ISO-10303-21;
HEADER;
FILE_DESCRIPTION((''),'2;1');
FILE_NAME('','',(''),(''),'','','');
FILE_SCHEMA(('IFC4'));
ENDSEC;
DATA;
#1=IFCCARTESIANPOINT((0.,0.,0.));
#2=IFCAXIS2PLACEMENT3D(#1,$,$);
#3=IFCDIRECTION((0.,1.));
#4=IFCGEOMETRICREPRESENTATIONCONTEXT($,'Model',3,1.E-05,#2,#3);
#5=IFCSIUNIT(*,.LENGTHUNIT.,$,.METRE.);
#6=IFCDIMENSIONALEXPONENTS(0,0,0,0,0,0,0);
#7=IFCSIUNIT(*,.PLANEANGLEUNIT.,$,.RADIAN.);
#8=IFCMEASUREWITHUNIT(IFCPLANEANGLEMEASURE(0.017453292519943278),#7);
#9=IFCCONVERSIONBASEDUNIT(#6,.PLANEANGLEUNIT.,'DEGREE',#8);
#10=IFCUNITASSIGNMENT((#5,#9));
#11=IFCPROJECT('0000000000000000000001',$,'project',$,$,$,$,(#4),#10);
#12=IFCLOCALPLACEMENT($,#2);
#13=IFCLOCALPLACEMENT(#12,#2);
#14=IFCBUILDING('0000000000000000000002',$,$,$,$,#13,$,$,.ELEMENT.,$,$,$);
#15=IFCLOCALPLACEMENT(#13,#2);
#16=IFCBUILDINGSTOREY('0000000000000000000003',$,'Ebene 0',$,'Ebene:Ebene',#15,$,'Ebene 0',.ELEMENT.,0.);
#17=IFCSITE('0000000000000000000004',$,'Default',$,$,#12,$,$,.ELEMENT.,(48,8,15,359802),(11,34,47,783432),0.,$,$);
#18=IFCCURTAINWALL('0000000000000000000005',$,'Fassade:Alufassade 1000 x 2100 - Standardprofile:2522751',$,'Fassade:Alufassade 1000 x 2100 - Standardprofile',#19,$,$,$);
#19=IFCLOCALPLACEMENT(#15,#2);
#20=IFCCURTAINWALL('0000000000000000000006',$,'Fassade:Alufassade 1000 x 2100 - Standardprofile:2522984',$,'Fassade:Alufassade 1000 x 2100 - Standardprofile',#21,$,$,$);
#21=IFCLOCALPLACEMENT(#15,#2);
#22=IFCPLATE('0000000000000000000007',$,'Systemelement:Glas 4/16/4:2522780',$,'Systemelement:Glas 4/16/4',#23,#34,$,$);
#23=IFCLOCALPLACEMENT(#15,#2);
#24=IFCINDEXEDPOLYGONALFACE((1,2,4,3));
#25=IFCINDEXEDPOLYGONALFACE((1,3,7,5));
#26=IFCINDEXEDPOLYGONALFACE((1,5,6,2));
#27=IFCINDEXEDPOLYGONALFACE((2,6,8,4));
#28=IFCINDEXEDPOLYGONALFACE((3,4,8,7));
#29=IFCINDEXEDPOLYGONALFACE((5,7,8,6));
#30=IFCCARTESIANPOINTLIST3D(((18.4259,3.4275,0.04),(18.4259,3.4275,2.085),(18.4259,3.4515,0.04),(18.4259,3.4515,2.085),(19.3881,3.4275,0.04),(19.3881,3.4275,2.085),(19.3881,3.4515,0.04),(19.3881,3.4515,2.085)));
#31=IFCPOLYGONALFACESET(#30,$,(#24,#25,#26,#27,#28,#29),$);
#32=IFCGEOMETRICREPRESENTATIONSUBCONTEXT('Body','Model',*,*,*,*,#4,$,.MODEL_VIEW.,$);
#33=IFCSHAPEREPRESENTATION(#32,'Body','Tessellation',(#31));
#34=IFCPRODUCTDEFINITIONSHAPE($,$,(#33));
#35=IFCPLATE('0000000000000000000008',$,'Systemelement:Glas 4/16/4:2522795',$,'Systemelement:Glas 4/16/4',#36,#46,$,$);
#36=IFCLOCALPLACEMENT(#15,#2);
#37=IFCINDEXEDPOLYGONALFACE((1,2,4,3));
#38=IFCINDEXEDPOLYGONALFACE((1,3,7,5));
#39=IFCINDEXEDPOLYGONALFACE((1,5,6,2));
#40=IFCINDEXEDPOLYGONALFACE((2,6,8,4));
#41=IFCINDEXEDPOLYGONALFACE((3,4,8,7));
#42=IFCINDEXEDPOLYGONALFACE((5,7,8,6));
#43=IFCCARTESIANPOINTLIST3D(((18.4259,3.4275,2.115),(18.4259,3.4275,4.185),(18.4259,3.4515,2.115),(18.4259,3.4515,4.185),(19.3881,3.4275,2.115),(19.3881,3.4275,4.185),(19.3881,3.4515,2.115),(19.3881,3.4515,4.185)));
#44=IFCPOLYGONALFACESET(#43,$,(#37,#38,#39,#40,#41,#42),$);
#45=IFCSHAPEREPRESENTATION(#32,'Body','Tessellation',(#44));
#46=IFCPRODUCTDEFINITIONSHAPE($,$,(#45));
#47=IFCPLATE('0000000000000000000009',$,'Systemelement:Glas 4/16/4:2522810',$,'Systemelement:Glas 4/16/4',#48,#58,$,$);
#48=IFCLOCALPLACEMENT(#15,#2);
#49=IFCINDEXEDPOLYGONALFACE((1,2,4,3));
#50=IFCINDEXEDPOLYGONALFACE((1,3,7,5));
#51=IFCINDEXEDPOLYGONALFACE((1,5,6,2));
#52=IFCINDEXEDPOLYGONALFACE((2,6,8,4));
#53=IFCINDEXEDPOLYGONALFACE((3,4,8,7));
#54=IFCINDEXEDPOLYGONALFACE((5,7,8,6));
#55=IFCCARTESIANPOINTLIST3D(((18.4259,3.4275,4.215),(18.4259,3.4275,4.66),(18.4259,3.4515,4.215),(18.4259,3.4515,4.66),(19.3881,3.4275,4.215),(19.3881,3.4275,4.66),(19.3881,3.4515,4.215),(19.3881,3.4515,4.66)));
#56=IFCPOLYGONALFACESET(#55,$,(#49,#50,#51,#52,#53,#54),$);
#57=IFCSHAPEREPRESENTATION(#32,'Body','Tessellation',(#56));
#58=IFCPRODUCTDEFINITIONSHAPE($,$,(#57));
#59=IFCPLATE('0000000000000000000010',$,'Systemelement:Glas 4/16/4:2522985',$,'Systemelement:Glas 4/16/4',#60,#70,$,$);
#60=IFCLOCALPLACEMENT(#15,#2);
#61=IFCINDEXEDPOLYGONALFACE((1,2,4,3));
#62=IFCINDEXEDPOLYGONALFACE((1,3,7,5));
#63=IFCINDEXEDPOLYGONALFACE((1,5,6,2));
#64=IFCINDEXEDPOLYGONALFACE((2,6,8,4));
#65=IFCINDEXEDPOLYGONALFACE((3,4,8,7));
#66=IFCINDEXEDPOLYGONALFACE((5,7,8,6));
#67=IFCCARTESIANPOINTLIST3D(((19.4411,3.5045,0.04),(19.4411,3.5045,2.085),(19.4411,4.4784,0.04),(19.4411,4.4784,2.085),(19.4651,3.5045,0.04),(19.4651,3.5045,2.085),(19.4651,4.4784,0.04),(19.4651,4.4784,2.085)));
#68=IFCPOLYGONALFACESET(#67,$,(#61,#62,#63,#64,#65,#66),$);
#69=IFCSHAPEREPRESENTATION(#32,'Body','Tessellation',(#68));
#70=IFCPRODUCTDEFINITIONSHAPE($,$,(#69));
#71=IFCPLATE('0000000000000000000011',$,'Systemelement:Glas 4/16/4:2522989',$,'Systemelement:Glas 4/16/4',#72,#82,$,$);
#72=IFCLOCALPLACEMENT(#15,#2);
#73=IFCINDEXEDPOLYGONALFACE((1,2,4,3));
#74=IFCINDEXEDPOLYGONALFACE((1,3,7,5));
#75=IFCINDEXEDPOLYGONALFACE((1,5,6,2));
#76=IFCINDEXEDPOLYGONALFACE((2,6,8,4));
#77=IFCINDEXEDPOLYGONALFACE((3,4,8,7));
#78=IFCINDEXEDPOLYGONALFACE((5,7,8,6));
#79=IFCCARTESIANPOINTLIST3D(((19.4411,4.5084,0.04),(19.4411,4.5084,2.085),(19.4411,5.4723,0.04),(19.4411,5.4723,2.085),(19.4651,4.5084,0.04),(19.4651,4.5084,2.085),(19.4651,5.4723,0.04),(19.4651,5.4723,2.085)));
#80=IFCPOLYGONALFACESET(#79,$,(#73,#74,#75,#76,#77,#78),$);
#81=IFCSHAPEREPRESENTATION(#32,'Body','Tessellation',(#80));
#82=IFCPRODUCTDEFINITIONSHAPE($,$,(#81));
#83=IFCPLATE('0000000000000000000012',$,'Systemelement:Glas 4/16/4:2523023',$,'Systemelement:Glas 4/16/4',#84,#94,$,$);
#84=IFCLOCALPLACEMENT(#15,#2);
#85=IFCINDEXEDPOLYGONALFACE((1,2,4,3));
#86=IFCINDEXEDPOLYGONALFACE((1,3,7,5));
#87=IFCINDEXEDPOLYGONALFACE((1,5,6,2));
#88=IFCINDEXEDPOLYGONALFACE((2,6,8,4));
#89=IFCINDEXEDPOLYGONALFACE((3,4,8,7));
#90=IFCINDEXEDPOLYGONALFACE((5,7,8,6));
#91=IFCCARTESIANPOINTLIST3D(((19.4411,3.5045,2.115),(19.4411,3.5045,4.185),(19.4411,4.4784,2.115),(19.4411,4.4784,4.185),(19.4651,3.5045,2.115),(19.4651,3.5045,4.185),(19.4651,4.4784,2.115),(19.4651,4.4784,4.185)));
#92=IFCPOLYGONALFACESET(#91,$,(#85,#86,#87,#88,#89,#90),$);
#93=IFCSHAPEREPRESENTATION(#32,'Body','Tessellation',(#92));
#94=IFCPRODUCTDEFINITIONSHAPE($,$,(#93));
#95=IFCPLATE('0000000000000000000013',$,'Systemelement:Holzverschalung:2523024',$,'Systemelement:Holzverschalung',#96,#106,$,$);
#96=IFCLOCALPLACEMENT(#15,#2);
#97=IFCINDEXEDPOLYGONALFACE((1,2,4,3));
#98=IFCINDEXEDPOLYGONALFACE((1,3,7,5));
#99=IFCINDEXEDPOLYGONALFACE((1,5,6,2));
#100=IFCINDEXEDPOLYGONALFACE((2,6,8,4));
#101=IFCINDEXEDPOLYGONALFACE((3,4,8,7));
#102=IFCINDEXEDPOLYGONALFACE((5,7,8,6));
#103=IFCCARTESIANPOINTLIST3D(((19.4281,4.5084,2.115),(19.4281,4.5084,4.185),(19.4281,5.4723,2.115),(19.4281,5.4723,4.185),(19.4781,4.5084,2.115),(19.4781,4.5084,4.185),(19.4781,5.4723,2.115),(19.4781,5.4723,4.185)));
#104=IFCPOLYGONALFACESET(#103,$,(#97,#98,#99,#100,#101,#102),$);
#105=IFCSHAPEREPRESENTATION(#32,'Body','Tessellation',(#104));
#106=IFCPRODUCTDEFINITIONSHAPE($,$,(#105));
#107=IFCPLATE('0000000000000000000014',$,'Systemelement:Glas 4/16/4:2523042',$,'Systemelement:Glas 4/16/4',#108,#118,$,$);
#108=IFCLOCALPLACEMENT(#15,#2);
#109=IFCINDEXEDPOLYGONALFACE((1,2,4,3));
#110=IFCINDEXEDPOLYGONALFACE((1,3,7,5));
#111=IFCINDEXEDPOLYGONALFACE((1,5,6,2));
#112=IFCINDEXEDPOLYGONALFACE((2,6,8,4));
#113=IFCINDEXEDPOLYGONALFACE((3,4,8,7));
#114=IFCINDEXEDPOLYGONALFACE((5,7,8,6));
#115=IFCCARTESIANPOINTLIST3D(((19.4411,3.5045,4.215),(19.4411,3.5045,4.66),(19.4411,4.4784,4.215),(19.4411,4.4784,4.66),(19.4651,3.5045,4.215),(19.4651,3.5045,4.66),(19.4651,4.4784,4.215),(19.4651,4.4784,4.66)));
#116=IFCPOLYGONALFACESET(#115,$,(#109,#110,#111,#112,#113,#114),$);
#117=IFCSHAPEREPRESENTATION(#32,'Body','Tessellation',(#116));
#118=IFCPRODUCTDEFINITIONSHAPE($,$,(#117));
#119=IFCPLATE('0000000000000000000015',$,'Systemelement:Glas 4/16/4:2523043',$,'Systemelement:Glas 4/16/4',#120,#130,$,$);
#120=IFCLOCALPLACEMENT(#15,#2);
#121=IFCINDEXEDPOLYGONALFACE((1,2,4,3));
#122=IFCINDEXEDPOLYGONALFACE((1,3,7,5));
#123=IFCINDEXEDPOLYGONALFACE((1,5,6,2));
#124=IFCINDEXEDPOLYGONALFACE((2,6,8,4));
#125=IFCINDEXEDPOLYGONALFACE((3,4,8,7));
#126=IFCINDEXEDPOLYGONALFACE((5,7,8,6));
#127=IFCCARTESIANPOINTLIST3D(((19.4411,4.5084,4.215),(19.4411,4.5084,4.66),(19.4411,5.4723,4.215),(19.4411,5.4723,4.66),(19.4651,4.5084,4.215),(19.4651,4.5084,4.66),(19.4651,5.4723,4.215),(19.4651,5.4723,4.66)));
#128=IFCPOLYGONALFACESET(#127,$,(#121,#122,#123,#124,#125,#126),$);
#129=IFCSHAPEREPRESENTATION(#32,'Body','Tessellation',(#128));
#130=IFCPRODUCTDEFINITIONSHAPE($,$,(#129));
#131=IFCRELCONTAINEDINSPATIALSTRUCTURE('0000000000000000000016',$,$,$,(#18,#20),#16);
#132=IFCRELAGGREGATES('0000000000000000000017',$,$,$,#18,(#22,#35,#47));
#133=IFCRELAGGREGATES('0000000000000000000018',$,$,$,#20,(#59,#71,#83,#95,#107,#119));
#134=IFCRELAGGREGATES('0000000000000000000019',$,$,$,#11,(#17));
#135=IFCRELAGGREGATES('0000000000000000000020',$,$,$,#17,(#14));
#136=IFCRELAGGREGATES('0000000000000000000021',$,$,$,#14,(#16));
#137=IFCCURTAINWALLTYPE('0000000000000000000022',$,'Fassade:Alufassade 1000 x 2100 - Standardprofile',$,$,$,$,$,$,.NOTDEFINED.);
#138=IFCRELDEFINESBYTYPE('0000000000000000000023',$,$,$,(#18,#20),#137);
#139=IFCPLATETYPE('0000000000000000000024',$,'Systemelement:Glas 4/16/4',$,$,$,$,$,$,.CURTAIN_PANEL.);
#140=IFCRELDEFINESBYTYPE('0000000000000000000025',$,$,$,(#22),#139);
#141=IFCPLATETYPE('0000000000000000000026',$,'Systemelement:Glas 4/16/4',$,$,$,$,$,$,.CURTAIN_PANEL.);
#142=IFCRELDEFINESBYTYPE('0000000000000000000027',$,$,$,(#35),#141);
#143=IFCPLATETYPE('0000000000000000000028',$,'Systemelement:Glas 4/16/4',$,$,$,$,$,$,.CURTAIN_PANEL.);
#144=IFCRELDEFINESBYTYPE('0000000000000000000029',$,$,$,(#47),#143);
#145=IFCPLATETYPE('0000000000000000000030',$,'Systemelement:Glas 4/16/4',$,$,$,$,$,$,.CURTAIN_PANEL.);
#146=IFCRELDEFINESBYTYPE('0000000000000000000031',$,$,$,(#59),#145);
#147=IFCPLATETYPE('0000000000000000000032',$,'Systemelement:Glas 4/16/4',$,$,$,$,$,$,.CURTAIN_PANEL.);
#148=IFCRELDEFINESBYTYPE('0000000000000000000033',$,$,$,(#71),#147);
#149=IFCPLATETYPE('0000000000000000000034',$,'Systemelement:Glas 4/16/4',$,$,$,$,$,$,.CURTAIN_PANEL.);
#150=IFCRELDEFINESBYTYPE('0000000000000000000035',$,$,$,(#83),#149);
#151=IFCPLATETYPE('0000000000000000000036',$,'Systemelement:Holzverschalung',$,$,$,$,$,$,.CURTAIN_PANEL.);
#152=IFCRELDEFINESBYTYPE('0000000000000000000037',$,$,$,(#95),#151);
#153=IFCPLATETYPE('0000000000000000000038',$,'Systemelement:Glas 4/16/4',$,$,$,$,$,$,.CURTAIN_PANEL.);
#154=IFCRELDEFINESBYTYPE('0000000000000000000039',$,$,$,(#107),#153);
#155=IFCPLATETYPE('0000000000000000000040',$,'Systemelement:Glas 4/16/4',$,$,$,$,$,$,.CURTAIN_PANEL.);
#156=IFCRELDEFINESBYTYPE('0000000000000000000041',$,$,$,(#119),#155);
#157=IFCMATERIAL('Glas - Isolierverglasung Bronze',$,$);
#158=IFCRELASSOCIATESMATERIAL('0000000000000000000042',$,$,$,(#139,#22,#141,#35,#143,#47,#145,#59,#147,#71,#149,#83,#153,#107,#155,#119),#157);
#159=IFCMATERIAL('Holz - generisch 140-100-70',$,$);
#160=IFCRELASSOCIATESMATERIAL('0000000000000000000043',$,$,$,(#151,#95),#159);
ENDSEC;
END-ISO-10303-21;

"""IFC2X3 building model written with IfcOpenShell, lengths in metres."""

from ifc_helpers import new_model, entity, si_unit, converted_unit, direction, frame, origin, origin_2d_with_axis, place, context, subcontext, project, spatial, rectangle, extrude, source, transform, mapped, material, type_object, type_shapes, element, aggregate, save


model = new_model("IFC2X3")

# Units and contexts
model_context = context("Model", 3, precision=1e-05, world=origin(), true_north=direction((0.0, 1.0)))
body_context = subcontext(model_context, "Body", "Model", "MODEL_VIEW")
ifc_project = project(units=[si_unit("LENGTHUNIT", "METRE"), converted_unit("PLANEANGLEUNIT", "DEGREE", entity("IfcPlaneAngleMeasure", 0.017453292519943278), si_unit("PLANEANGLEUNIT", "RADIAN"), dimensions=[0, 0, 0, 0, 0, 0, 0])], contexts=[model_context])

# Site, building, storey
site_placement = place(None, origin())
site = spatial("IfcSite", under=ifc_project, at=site_placement, Name="Default", CompositionType="ELEMENT", RefLatitude=(48, 8, 15, 359802), RefLongitude=(11, 34, 47, 783432), RefElevation=0.0)
building_placement = place(site_placement, origin())
building = spatial("IfcBuilding", under=site, at=building_placement, CompositionType="ELEMENT")
storey_placement = place(building_placement, origin())
storey = spatial("IfcBuildingStorey", under=building, at=storey_placement, Name="Ebene 0", ObjectType="Ebene:Ebene", LongName="Ebene 0", CompositionType="ELEMENT", Elevation=0.0)

# Curtain walls
curtain_wall_type = type_object("IfcCurtainWallType", Name="Fassade:Alufassade 1000 x 2100 - Standardprofile", PredefinedType="NOTDEFINED")
curtain_wall_1_placement = place(storey_placement, origin())
curtain_wall_1 = element("IfcCurtainWall", 1, at=curtain_wall_1_placement, inside=storey, type_object=curtain_wall_type, Name="Fassade:Alufassade 1000 x 2100 - Standardprofile:2522751", ObjectType="Fassade:Alufassade 1000 x 2100 - Standardprofile")
curtain_wall_2_placement = place(storey_placement, origin())
curtain_wall_2 = element("IfcCurtainWall", 2, at=curtain_wall_2_placement, inside=storey, type_object=curtain_wall_type, Name="Fassade:Alufassade 1000 x 2100 - Standardprofile:2522984", ObjectType="Fassade:Alufassade 1000 x 2100 - Standardprofile")

# Plates
ifc_material_1 = material(Name="Glas - Isolierverglasung Bronze")
plate_type_1 = type_object("IfcPlateType", Name="Systemelement:Glas 4/16/4", PredefinedType="CURTAIN_PANEL", material=ifc_material_1)
shared_shape_1 = source(origin(), body_context, "Body", "SweptSolid", [
    extrude(rectangle(XDim=0.024, YDim=0.9621, at=origin_2d_with_axis()), frame((0.0, 0.0, 0.0), z_axis=(0.0, 0.0, 1.0), x_axis=(0.0, 1.0, 0.0)), (0.0, 0.0, 1.0), 2.045),
])
type_shapes(plate_type_1, [shared_shape_1])
plate_1_placement = place(curtain_wall_1_placement, frame((18.907, 3.4395, 0.04)))
plate_1 = element("IfcPlate", 3, at=plate_1_placement, type_object=plate_type_1, material=ifc_material_1, Name="Systemelement:Glas 4/16/4:2522780", ObjectType="Systemelement:Glas 4/16/4", context=body_context, shape_type="MappedRepresentation", body=[
    mapped(shared_shape_1, transform((0.0, 0.0, 0.0), scale=1.0)),
])
plate_type_2 = type_object("IfcPlateType", Name="Systemelement:Glas 4/16/4", PredefinedType="CURTAIN_PANEL", material=ifc_material_1)
shared_shape_2 = source(origin(), body_context, "Body", "SweptSolid", [
    extrude(rectangle(XDim=0.024, YDim=0.9621, at=origin_2d_with_axis()), frame((0.0, 0.0, 0.0), z_axis=(0.0, 0.0, 1.0), x_axis=(0.0, 1.0, 0.0)), (0.0, 0.0, 1.0), 2.07),
])
type_shapes(plate_type_2, [shared_shape_2])
plate_2_placement = place(curtain_wall_1_placement, frame((18.907, 3.4395, 2.115)))
plate_2 = element("IfcPlate", 4, at=plate_2_placement, type_object=plate_type_2, material=ifc_material_1, Name="Systemelement:Glas 4/16/4:2522795", ObjectType="Systemelement:Glas 4/16/4", context=body_context, shape_type="MappedRepresentation", body=[
    mapped(shared_shape_2, transform((0.0, 0.0, 0.0), scale=1.0)),
])
plate_type_3 = type_object("IfcPlateType", Name="Systemelement:Glas 4/16/4", PredefinedType="CURTAIN_PANEL", material=ifc_material_1)
shared_shape_3 = source(origin(), body_context, "Body", "SweptSolid", [
    extrude(rectangle(XDim=0.024, YDim=0.9621, at=origin_2d_with_axis()), frame((0.0, 0.0, 0.0), z_axis=(0.0, 0.0, 1.0), x_axis=(0.0, 1.0, 0.0)), (0.0, 0.0, 1.0), 0.445),
])
type_shapes(plate_type_3, [shared_shape_3])
plate_3_placement = place(curtain_wall_1_placement, frame((18.907, 3.4395, 4.215)))
plate_3 = element("IfcPlate", 5, at=plate_3_placement, type_object=plate_type_3, material=ifc_material_1, Name="Systemelement:Glas 4/16/4:2522810", ObjectType="Systemelement:Glas 4/16/4", context=body_context, shape_type="MappedRepresentation", body=[
    mapped(shared_shape_3, transform((0.0, 0.0, 0.0), scale=1.0)),
])
aggregate(curtain_wall_1, [plate_1, plate_2, plate_3])
plate_type_4 = type_object("IfcPlateType", Name="Systemelement:Glas 4/16/4", PredefinedType="CURTAIN_PANEL", material=ifc_material_1)
shared_shape_4 = source(origin(), body_context, "Body", "SweptSolid", [
    extrude(rectangle(XDim=0.024, YDim=0.9739, at=origin_2d_with_axis()), frame((0.0, 0.0, 0.0), z_axis=(0.0, 0.0, 1.0), x_axis=(0.0, 1.0, 0.0)), (0.0, 0.0, 1.0), 2.045),
])
type_shapes(plate_type_4, [shared_shape_4])
plate_4_placement = place(curtain_wall_2_placement, frame((19.4531, 3.9914, 0.04), z_axis=(0.0, 0.0, 1.0), x_axis=(0.0, 1.0, 0.0)))
plate_4 = element("IfcPlate", 6, at=plate_4_placement, type_object=plate_type_4, material=ifc_material_1, Name="Systemelement:Glas 4/16/4:2522985", ObjectType="Systemelement:Glas 4/16/4", context=body_context, shape_type="MappedRepresentation", body=[
    mapped(shared_shape_4, transform((0.0, 0.0, 0.0), scale=1.0)),
])
plate_type_5 = type_object("IfcPlateType", Name="Systemelement:Glas 4/16/4", PredefinedType="CURTAIN_PANEL", material=ifc_material_1)
shared_shape_5 = source(origin(), body_context, "Body", "SweptSolid", [
    extrude(rectangle(XDim=0.024, YDim=0.9639, at=origin_2d_with_axis()), frame((0.0, 0.0, 0.0), z_axis=(0.0, 0.0, 1.0), x_axis=(0.0, 1.0, 0.0)), (0.0, 0.0, 1.0), 2.045),
])
type_shapes(plate_type_5, [shared_shape_5])
plate_5_placement = place(curtain_wall_2_placement, frame((19.4531, 4.9903, 0.04), z_axis=(0.0, 0.0, 1.0), x_axis=(0.0, 1.0, 0.0)))
plate_5 = element("IfcPlate", 7, at=plate_5_placement, type_object=plate_type_5, material=ifc_material_1, Name="Systemelement:Glas 4/16/4:2522989", ObjectType="Systemelement:Glas 4/16/4", context=body_context, shape_type="MappedRepresentation", body=[
    mapped(shared_shape_5, transform((0.0, 0.0, 0.0), scale=1.0)),
])
plate_type_6 = type_object("IfcPlateType", Name="Systemelement:Glas 4/16/4", PredefinedType="CURTAIN_PANEL", material=ifc_material_1)
shared_shape_6 = source(origin(), body_context, "Body", "SweptSolid", [
    extrude(rectangle(XDim=0.024, YDim=0.9739, at=origin_2d_with_axis()), frame((0.0, 0.0, 0.0), z_axis=(0.0, 0.0, 1.0), x_axis=(0.0, 1.0, 0.0)), (0.0, 0.0, 1.0), 2.07),
])
type_shapes(plate_type_6, [shared_shape_6])
plate_6_placement = place(curtain_wall_2_placement, frame((19.4531, 3.9914, 2.115), z_axis=(0.0, 0.0, 1.0), x_axis=(0.0, 1.0, 0.0)))
plate_6 = element("IfcPlate", 8, at=plate_6_placement, type_object=plate_type_6, material=ifc_material_1, Name="Systemelement:Glas 4/16/4:2523023", ObjectType="Systemelement:Glas 4/16/4", context=body_context, shape_type="MappedRepresentation", body=[
    mapped(shared_shape_6, transform((0.0, 0.0, 0.0), scale=1.0)),
])
ifc_material_2 = material(Name="Holz - generisch 140-100-70")
plate_type_7 = type_object("IfcPlateType", Name="Systemelement:Holzverschalung", PredefinedType="CURTAIN_PANEL", material=ifc_material_2)
shared_shape_7 = source(origin(), body_context, "Body", "SweptSolid", [
    extrude(rectangle(XDim=0.05, YDim=0.9639, at=origin_2d_with_axis()), frame((0.0, 0.0, 0.0), z_axis=(0.0, 0.0, 1.0), x_axis=(0.0, 1.0, 0.0)), (0.0, 0.0, 1.0), 2.07),
])
type_shapes(plate_type_7, [shared_shape_7])
plate_7_placement = place(curtain_wall_2_placement, frame((19.4531, 4.9903, 2.115), z_axis=(0.0, 0.0, 1.0), x_axis=(0.0, 1.0, 0.0)))
plate_7 = element("IfcPlate", 9, at=plate_7_placement, type_object=plate_type_7, material=ifc_material_2, Name="Systemelement:Holzverschalung:2523024", ObjectType="Systemelement:Holzverschalung", context=body_context, shape_type="MappedRepresentation", body=[
    mapped(shared_shape_7, transform((0.0, 0.0, 0.0), scale=1.0)),
])
plate_type_8 = type_object("IfcPlateType", Name="Systemelement:Glas 4/16/4", PredefinedType="CURTAIN_PANEL", material=ifc_material_1)
shared_shape_8 = source(origin(), body_context, "Body", "SweptSolid", [
    extrude(rectangle(XDim=0.024, YDim=0.9739, at=origin_2d_with_axis()), frame((0.0, 0.0, 0.0), z_axis=(0.0, 0.0, 1.0), x_axis=(0.0, 1.0, 0.0)), (0.0, 0.0, 1.0), 0.445),
])
type_shapes(plate_type_8, [shared_shape_8])
plate_8_placement = place(curtain_wall_2_placement, frame((19.4531, 3.9914, 4.215), z_axis=(0.0, 0.0, 1.0), x_axis=(0.0, 1.0, 0.0)))
plate_8 = element("IfcPlate", 10, at=plate_8_placement, type_object=plate_type_8, material=ifc_material_1, Name="Systemelement:Glas 4/16/4:2523042", ObjectType="Systemelement:Glas 4/16/4", context=body_context, shape_type="MappedRepresentation", body=[
    mapped(shared_shape_8, transform((0.0, 0.0, 0.0), scale=1.0)),
])
plate_type_9 = type_object("IfcPlateType", Name="Systemelement:Glas 4/16/4", PredefinedType="CURTAIN_PANEL", material=ifc_material_1)
shared_shape_9 = source(origin(), body_context, "Body", "SweptSolid", [
    extrude(rectangle(XDim=0.024, YDim=0.9639, at=origin_2d_with_axis()), frame((0.0, 0.0, 0.0), z_axis=(0.0, 0.0, 1.0), x_axis=(0.0, 1.0, 0.0)), (0.0, 0.0, 1.0), 0.445),
])
type_shapes(plate_type_9, [shared_shape_9])
plate_9_placement = place(curtain_wall_2_placement, frame((19.4531, 4.9903, 4.215), z_axis=(0.0, 0.0, 1.0), x_axis=(0.0, 1.0, 0.0)))
plate_9 = element("IfcPlate", 11, at=plate_9_placement, type_object=plate_type_9, material=ifc_material_1, Name="Systemelement:Glas 4/16/4:2523043", ObjectType="Systemelement:Glas 4/16/4", context=body_context, shape_type="MappedRepresentation", body=[
    mapped(shared_shape_9, transform((0.0, 0.0, 0.0), scale=1.0)),
])
aggregate(curtain_wall_2, [plate_4, plate_5, plate_6, plate_7, plate_8, plate_9])

save(model, "model.ifc")
